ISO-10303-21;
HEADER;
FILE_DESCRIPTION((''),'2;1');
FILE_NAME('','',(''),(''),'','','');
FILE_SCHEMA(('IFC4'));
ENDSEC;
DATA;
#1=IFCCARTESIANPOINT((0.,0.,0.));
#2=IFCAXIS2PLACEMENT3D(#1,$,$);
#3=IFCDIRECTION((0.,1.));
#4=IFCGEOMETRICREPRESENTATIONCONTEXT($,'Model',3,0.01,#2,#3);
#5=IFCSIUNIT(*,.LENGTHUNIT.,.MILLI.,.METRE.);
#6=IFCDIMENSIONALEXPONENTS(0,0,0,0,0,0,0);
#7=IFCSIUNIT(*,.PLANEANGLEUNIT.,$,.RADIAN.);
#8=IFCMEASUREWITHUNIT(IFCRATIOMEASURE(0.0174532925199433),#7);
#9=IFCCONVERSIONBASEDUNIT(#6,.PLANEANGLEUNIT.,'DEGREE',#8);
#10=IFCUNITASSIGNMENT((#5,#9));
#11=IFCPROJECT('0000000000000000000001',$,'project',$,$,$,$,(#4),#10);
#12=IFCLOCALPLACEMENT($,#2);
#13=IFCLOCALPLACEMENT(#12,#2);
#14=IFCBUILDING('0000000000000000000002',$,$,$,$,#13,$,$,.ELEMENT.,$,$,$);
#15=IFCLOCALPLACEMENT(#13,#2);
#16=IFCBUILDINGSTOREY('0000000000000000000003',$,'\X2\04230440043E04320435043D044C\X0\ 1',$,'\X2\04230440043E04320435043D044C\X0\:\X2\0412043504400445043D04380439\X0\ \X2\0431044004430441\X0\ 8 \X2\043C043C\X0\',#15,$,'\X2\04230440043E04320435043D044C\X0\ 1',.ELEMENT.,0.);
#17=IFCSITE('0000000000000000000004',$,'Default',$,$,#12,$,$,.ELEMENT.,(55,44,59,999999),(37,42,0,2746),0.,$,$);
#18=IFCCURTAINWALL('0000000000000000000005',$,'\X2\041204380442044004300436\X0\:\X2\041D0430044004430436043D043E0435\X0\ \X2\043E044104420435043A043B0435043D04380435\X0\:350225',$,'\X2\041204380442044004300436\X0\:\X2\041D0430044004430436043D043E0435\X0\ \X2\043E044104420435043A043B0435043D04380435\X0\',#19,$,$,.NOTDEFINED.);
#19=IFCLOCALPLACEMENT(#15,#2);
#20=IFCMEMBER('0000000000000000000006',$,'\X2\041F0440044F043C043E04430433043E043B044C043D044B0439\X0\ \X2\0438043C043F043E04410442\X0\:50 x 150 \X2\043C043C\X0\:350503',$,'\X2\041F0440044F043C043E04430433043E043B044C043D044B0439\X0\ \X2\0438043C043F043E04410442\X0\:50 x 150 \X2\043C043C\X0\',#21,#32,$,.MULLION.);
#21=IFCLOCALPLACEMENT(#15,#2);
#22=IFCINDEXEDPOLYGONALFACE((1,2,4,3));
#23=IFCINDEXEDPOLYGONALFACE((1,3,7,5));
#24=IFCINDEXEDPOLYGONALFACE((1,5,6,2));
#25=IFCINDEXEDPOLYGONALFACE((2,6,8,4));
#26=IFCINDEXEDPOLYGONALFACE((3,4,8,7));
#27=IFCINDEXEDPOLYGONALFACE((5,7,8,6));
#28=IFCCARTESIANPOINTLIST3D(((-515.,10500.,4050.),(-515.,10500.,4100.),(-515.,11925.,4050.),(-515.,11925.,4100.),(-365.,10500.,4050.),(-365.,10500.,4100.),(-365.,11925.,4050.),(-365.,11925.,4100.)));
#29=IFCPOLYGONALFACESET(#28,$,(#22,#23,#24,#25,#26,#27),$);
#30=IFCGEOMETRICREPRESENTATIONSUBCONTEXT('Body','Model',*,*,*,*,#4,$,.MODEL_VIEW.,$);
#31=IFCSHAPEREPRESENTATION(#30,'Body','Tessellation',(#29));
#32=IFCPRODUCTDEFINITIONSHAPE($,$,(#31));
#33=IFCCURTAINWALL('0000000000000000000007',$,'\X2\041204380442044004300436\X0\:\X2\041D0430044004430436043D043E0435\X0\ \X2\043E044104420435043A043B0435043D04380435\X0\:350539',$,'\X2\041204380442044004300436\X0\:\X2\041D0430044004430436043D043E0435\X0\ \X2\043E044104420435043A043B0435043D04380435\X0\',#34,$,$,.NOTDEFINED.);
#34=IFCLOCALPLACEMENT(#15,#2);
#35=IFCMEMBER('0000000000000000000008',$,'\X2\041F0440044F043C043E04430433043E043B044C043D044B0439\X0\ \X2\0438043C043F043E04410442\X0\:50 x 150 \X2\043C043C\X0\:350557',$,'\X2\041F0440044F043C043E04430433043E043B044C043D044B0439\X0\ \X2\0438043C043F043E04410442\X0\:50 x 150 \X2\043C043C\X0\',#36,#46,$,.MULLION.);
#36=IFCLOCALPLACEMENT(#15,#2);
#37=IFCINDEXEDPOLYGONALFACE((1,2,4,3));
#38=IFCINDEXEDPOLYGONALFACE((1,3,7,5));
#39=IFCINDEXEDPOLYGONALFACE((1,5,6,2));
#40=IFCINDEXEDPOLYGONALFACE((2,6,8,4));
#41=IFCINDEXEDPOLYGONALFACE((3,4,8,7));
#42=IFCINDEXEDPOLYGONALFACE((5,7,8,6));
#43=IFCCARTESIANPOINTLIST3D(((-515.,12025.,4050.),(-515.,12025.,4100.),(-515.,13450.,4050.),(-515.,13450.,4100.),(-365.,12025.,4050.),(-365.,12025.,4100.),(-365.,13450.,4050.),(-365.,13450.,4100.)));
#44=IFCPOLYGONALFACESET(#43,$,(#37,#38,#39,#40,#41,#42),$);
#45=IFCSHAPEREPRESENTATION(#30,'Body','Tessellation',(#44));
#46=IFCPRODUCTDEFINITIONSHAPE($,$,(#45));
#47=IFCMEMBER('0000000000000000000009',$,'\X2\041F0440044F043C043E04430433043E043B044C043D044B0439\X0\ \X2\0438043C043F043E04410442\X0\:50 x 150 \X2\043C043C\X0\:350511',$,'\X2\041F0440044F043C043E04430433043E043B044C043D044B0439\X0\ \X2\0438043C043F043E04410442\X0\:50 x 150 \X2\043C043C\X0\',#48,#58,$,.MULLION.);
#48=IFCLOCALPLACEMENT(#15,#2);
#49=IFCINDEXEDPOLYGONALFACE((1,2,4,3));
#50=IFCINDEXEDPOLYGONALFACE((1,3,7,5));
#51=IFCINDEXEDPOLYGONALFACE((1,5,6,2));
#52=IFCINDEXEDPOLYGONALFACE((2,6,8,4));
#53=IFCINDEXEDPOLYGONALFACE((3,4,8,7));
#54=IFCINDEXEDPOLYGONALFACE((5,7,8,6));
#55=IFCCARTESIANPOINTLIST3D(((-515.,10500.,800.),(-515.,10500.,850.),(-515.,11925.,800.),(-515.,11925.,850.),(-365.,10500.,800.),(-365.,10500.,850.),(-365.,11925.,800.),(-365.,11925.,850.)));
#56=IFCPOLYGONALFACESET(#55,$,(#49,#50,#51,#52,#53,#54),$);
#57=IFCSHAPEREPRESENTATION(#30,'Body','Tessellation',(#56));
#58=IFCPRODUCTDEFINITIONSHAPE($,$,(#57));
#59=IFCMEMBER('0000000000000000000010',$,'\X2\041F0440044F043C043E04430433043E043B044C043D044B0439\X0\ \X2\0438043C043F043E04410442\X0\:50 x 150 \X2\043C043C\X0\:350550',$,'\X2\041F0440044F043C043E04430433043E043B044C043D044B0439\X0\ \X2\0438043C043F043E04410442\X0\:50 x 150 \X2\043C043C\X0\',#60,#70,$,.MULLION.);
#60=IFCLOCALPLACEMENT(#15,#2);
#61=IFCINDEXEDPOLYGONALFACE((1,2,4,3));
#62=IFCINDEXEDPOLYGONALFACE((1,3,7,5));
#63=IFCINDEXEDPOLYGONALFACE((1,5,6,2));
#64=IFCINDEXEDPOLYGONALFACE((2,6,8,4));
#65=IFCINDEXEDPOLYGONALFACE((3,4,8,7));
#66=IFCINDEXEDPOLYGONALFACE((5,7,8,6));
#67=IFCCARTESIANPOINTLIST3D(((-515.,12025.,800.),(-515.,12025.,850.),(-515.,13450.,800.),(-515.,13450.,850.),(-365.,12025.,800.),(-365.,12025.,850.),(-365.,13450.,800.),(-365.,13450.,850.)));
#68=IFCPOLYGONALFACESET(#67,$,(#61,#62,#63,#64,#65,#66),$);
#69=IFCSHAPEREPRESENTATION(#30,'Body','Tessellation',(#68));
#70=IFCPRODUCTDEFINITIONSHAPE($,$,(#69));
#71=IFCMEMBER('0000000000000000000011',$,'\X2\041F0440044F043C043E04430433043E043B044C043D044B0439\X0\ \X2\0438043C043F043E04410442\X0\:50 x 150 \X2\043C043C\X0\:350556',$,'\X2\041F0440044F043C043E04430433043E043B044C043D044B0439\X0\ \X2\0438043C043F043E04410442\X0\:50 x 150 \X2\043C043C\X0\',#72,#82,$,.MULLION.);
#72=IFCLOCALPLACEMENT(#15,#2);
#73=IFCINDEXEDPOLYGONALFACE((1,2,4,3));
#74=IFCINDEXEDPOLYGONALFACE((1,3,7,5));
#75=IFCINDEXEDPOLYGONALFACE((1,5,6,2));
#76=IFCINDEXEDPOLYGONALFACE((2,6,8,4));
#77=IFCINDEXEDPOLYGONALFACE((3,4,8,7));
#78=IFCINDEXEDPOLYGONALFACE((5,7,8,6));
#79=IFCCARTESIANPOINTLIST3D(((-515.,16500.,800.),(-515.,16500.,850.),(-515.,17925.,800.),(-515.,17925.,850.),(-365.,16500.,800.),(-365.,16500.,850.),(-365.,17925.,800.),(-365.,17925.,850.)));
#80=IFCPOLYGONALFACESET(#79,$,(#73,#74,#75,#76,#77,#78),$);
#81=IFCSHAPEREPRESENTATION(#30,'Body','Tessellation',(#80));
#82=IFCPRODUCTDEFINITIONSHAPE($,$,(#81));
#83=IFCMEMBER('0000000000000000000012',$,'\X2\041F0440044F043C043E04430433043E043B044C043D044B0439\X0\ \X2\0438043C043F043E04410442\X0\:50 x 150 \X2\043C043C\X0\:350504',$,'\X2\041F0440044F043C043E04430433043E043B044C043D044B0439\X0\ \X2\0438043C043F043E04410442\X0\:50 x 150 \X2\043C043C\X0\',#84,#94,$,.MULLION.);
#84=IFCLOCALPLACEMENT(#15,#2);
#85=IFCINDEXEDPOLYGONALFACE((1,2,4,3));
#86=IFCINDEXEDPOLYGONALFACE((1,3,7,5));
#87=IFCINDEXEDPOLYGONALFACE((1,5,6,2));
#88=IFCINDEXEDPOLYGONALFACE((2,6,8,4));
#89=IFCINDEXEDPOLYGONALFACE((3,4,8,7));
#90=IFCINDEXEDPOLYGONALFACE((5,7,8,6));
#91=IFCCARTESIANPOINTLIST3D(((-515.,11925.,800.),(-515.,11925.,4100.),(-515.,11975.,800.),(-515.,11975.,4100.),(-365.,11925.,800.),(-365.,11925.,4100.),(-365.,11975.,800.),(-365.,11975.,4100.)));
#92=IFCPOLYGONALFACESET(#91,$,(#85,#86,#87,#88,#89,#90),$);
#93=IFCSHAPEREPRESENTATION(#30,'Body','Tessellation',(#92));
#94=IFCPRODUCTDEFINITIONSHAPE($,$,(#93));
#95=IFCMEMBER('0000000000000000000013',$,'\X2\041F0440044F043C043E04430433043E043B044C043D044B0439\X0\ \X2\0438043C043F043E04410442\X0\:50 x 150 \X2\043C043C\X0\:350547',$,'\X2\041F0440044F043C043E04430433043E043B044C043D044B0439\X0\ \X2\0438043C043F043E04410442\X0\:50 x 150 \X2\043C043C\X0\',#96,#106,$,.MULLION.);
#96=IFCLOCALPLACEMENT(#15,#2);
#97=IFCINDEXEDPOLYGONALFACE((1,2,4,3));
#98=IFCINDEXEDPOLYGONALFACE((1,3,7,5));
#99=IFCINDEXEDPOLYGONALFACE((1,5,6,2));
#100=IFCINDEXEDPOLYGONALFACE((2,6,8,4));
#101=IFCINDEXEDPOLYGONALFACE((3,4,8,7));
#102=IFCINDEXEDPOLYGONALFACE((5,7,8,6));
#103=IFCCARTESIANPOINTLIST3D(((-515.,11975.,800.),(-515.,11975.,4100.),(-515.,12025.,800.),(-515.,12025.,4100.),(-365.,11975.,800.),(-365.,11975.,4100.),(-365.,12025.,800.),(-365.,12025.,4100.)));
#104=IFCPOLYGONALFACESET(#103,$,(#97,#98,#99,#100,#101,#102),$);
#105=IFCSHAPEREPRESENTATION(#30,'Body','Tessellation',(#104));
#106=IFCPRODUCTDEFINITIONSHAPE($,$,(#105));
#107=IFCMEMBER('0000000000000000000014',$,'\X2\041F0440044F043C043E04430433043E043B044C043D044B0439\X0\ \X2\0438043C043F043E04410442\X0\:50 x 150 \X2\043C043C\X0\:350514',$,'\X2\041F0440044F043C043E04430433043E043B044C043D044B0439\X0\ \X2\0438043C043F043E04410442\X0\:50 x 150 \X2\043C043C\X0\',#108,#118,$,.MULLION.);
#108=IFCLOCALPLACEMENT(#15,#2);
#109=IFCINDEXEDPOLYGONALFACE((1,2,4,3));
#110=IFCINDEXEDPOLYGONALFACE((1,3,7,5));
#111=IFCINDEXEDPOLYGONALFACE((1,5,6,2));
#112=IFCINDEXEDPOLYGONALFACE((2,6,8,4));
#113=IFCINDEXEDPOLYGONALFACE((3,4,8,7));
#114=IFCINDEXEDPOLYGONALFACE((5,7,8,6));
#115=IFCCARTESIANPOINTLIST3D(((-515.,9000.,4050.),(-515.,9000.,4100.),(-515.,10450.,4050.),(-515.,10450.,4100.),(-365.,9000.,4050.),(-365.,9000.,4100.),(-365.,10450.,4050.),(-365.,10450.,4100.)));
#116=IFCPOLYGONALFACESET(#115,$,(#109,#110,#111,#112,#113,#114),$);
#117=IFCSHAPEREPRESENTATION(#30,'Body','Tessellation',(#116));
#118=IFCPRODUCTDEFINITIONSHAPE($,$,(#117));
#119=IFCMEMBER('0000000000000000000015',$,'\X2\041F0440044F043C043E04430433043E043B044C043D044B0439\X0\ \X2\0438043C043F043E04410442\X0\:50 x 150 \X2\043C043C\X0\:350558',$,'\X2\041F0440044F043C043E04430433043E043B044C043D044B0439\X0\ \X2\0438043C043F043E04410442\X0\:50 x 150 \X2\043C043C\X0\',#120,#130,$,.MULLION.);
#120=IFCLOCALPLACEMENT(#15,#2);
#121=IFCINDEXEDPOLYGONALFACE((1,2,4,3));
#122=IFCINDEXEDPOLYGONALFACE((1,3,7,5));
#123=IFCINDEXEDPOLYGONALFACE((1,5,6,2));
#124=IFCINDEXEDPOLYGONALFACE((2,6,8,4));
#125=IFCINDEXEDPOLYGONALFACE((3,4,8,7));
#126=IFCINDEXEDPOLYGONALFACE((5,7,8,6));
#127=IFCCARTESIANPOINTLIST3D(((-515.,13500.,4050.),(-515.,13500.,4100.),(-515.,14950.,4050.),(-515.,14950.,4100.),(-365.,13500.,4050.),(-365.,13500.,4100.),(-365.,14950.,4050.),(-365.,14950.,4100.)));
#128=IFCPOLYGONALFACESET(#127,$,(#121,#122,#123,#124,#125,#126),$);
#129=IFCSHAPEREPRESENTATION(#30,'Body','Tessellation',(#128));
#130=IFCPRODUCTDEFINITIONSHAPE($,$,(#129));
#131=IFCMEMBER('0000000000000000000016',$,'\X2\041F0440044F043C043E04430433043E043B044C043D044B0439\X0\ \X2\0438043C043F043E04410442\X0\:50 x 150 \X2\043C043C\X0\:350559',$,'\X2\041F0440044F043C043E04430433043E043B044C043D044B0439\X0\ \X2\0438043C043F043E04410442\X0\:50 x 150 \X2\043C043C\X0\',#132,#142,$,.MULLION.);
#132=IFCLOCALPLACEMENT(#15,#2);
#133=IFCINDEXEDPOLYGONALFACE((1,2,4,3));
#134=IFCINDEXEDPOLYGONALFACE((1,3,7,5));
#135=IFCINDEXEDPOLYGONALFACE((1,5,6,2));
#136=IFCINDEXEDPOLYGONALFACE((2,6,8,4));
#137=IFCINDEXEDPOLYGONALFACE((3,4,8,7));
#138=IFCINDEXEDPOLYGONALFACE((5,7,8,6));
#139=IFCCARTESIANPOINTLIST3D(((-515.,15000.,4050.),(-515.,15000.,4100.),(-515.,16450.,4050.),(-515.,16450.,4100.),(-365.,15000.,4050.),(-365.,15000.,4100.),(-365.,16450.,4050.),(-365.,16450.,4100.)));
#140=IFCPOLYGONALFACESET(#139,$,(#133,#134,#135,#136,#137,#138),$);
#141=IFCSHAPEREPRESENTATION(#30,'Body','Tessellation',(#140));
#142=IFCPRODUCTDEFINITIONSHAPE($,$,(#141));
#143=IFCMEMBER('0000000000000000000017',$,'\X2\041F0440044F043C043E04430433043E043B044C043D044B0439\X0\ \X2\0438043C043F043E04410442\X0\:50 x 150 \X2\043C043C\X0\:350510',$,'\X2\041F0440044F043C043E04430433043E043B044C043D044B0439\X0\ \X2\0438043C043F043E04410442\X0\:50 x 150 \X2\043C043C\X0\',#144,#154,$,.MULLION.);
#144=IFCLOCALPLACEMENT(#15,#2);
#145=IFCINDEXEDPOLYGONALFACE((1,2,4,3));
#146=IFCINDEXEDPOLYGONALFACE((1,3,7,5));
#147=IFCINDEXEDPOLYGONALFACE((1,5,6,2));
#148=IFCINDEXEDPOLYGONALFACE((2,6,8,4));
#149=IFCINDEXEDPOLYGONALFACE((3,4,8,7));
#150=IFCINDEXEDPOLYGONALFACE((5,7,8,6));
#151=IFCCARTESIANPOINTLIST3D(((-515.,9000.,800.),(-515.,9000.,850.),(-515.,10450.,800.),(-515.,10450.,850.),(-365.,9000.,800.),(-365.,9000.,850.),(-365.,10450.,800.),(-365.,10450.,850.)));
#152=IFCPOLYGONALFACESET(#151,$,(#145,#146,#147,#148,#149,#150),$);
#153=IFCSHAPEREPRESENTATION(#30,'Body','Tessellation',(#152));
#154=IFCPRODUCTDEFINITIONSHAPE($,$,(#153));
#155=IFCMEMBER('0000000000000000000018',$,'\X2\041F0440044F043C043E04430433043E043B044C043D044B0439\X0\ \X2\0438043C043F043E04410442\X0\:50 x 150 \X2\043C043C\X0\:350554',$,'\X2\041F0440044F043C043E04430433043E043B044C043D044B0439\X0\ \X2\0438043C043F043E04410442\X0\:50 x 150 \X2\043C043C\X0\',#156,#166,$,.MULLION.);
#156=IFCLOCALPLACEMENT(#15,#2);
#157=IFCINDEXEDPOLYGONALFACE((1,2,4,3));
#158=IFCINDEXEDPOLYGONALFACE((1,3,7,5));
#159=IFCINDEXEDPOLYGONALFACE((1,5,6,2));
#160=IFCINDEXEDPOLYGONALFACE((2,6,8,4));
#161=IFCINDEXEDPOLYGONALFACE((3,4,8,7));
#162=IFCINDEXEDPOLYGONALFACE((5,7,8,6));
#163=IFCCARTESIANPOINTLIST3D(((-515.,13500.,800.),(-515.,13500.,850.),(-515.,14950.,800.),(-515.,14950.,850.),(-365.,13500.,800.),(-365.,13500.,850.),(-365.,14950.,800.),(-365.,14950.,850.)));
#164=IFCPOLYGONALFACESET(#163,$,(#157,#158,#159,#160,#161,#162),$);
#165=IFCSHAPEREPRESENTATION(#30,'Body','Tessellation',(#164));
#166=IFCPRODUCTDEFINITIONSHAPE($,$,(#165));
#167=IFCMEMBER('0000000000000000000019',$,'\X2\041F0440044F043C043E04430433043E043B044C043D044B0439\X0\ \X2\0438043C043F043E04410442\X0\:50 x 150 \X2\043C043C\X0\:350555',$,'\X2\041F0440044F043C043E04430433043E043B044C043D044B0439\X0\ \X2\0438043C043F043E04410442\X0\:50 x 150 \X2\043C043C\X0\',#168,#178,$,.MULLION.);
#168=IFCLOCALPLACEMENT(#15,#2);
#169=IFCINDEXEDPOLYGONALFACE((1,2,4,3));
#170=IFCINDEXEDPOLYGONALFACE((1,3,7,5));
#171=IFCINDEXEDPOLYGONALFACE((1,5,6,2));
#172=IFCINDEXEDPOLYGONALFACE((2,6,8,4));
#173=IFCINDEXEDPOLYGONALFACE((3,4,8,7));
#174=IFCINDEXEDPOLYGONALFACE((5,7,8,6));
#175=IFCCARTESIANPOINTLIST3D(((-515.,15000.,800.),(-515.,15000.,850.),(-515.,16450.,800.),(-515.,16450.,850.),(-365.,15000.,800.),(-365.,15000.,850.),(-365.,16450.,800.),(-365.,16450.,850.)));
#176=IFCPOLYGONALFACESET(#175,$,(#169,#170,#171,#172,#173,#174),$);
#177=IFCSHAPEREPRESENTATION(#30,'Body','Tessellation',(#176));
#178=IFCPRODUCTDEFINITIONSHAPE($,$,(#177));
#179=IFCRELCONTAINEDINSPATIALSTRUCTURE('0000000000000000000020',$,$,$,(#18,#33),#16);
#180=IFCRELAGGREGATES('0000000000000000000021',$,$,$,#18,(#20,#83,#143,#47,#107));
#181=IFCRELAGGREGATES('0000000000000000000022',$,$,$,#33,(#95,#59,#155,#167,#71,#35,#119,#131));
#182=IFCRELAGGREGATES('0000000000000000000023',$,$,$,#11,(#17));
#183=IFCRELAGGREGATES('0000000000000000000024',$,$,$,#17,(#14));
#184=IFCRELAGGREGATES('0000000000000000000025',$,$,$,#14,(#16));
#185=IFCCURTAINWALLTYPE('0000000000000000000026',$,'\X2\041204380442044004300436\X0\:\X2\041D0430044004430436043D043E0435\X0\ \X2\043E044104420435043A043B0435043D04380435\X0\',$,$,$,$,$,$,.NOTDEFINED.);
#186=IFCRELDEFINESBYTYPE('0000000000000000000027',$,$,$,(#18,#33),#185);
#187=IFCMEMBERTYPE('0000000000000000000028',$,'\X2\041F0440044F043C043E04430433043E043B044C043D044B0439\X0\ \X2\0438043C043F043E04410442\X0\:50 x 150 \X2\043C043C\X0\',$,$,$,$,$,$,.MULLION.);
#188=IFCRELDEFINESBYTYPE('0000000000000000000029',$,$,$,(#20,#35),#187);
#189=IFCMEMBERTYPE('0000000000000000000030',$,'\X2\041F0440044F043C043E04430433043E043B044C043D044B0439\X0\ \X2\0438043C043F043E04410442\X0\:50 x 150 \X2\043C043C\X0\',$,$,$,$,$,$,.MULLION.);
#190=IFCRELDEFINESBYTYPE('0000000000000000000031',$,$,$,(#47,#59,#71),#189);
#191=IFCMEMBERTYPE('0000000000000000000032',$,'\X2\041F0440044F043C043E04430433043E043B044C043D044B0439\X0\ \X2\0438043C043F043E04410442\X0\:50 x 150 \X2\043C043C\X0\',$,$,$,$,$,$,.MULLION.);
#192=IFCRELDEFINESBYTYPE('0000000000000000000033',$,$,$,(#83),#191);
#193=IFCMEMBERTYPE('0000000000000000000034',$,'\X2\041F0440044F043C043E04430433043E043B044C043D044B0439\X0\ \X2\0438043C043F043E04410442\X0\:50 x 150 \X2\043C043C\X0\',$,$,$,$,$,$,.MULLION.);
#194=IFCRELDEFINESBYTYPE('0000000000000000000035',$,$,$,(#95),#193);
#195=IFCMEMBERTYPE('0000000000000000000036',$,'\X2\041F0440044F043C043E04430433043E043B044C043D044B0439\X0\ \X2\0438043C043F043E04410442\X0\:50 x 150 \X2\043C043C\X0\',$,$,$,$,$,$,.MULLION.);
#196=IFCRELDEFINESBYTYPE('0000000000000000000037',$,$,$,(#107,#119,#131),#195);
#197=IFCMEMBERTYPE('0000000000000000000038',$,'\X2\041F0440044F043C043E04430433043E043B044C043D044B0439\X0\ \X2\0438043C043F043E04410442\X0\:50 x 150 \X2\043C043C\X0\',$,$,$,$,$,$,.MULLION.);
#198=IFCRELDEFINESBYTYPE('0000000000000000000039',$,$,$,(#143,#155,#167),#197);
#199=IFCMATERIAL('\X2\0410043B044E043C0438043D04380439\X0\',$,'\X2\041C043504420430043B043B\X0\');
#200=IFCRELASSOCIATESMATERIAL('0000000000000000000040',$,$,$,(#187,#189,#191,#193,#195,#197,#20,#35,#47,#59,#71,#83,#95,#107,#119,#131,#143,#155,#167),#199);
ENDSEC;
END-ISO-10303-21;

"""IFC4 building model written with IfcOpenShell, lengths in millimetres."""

from ifc_helpers import new_model, entity, si_unit, converted_unit, direction, frame, origin, origin_2d_with_axis, place, context, subcontext, project, spatial, rectangle, extrude, source, transform, mapped, material, material_profile, profile_set, profile_usage, type_object, type_shapes, element, aggregate, save


model = new_model("IFC4")

# Units and contexts
model_context = context("Model", 3, precision=0.01, world=origin(), true_north=direction((0.0, 1.0)))
body_context = subcontext(model_context, "Body", "Model", "MODEL_VIEW")
ifc_project = project(units=[si_unit("LENGTHUNIT", "METRE", prefix="MILLI"), converted_unit("PLANEANGLEUNIT", "DEGREE", entity("IfcRatioMeasure", 0.0174532925199433), si_unit("PLANEANGLEUNIT", "RADIAN"), dimensions=[0, 0, 0, 0, 0, 0, 0])], contexts=[model_context])

# Site, building, storey
site_placement = place(None, origin())
site = spatial("IfcSite", under=ifc_project, at=site_placement, Name="Default", CompositionType="ELEMENT", RefLatitude=(55, 44, 59, 999999), RefLongitude=(37, 42, 0, 2746), RefElevation=0.0)
building_placement = place(site_placement, origin())
building = spatial("IfcBuilding", under=site, at=building_placement, CompositionType="ELEMENT")
storey_placement = place(building_placement, origin())
storey = spatial("IfcBuildingStorey", under=building, at=storey_placement, Name="Уровень 1", ObjectType="Уровень:Верхний брус 8 мм", LongName="Уровень 1", CompositionType="ELEMENT", Elevation=0.0)

# Curtain walls, members
curtain_wall_type = type_object("IfcCurtainWallType", Name="Витраж:Наружное остекление", PredefinedType="NOTDEFINED")
curtain_wall_1_placement = place(storey_placement, origin())
curtain_wall_1 = element("IfcCurtainWall", 1, at=curtain_wall_1_placement, inside=storey, type_object=curtain_wall_type, Name="Витраж:Наружное остекление:350225", ObjectType="Витраж:Наружное остекление", PredefinedType="NOTDEFINED")
ifc_material_1 = material(Name="Алюминий", Category="Металл")
ifc_material_profile = material_profile(ifc_material_1, rectangle(XDim=150.0, YDim=50.0, at=origin_2d_with_axis()), Name="50 x 150 мм")
ifc_profile_set = profile_set([ifc_material_profile], Name="50 x 150 мм")
ifc_profile_usage_1 = profile_usage(ifc_profile_set)
member_type_1 = type_object("IfcMemberType", Name="Прямоугольный импост:50 x 150 мм", PredefinedType="MULLION", material=ifc_profile_set)
shared_shape_1 = source(origin(), body_context, "Body", "SweptSolid", [
    extrude(rectangle(XDim=150.0, YDim=50.0, at=origin_2d_with_axis()), frame((-25.0, 0.0, -1425.0), z_axis=(0.0, 0.0, 1.0), x_axis=(0.0, -1.0, 0.0)), (0.0, 0.0, 1.0), 1425.0),
])
type_shapes(member_type_1, [shared_shape_1])
member_1_placement = place(storey_placement, frame((-440.0, 11925.0, 4100.0), z_axis=(0.0, 1.0, 0.0), x_axis=(0.0, 0.0, 1.0)))
member_1 = element("IfcMember", 2, at=member_1_placement, type_object=member_type_1, material=ifc_profile_usage_1, Name="Прямоугольный импост:50 x 150 мм:350503", ObjectType="Прямоугольный импост:50 x 150 мм", PredefinedType="MULLION", context=body_context, shape_type="MappedRepresentation", body=[
    mapped(shared_shape_1, transform((0.0, 0.0, 0.0), scale=1.0)),
])
curtain_wall_2_placement = place(storey_placement, origin())
curtain_wall_2 = element("IfcCurtainWall", 3, at=curtain_wall_2_placement, inside=storey, type_object=curtain_wall_type, Name="Витраж:Наружное остекление:350539", ObjectType="Витраж:Наружное остекление", PredefinedType="NOTDEFINED")
ifc_profile_usage_2 = profile_usage(ifc_profile_set)
member_2_placement = place(storey_placement, frame((-440.0, 13450.0, 4100.0), z_axis=(0.0, 1.0, 0.0), x_axis=(0.0, 0.0, 1.0)))
member_2 = element("IfcMember", 4, at=member_2_placement, type_object=member_type_1, material=ifc_profile_usage_2, Name="Прямоугольный импост:50 x 150 мм:350557", ObjectType="Прямоугольный импост:50 x 150 мм", PredefinedType="MULLION", context=body_context, shape_type="MappedRepresentation", body=[
    mapped(shared_shape_1, transform((0.0, 0.0, 0.0), scale=1.0)),
])

# Members
ifc_profile_usage_3 = profile_usage(ifc_profile_set)
member_type_2 = type_object("IfcMemberType", Name="Прямоугольный импост:50 x 150 мм", PredefinedType="MULLION", material=ifc_profile_set)
shared_shape_2 = source(origin(), body_context, "Body", "SweptSolid", [
    extrude(rectangle(XDim=150.0, YDim=50.0, at=origin_2d_with_axis()), frame((-25.0, 0.0, -1425.0), z_axis=(0.0, 0.0, 1.0), x_axis=(0.0, -1.0, 0.0)), (0.0, 0.0, 1.0), 1425.0),
])
type_shapes(member_type_2, [shared_shape_2])
member_3_placement = place(storey_placement, frame((-440.0, 10500.0, 800.0), z_axis=(0.0, -1.0, 0.0), x_axis=(0.0, 0.0, -1.0)))
member_3 = element("IfcMember", 5, at=member_3_placement, type_object=member_type_2, material=ifc_profile_usage_3, Name="Прямоугольный импост:50 x 150 мм:350511", ObjectType="Прямоугольный импост:50 x 150 мм", PredefinedType="MULLION", context=body_context, shape_type="MappedRepresentation", body=[
    mapped(shared_shape_2, transform((0.0, 0.0, 0.0), scale=1.0)),
])
ifc_profile_usage_4 = profile_usage(ifc_profile_set)
member_4_placement = place(storey_placement, frame((-440.0, 12025.0, 800.0), z_axis=(0.0, -1.0, 0.0), x_axis=(0.0, 0.0, -1.0)))
member_4 = element("IfcMember", 6, at=member_4_placement, type_object=member_type_2, material=ifc_profile_usage_4, Name="Прямоугольный импост:50 x 150 мм:350550", ObjectType="Прямоугольный импост:50 x 150 мм", PredefinedType="MULLION", context=body_context, shape_type="MappedRepresentation", body=[
    mapped(shared_shape_2, transform((0.0, 0.0, 0.0), scale=1.0)),
])
ifc_profile_usage_5 = profile_usage(ifc_profile_set)
member_5_placement = place(storey_placement, frame((-440.0, 16500.0, 800.0), z_axis=(0.0, -1.0, 0.0), x_axis=(0.0, 0.0, -1.0)))
member_5 = element("IfcMember", 7, at=member_5_placement, type_object=member_type_2, material=ifc_profile_usage_5, Name="Прямоугольный импост:50 x 150 мм:350556", ObjectType="Прямоугольный импост:50 x 150 мм", PredefinedType="MULLION", context=body_context, shape_type="MappedRepresentation", body=[
    mapped(shared_shape_2, transform((0.0, 0.0, 0.0), scale=1.0)),
])
ifc_profile_usage_6 = profile_usage(ifc_profile_set)
member_type_3 = type_object("IfcMemberType", Name="Прямоугольный импост:50 x 150 мм", PredefinedType="MULLION", material=ifc_profile_set)
shared_shape_3 = source(origin(), body_context, "Body", "SweptSolid", [
    extrude(rectangle(XDim=150.0, YDim=50.0, at=origin_2d_with_axis()), frame((-25.0, 0.0, -3300.0), z_axis=(0.0, 0.0, 1.0), x_axis=(0.0, -1.0, 0.0)), (0.0, 0.0, 1.0), 3300.0),
])
type_shapes(member_type_3, [shared_shape_3])
member_6_placement = place(storey_placement, frame((-440.0, 11975.0, 800.0), z_axis=(0.0, 0.0, -1.0), x_axis=(0.0, 1.0, 0.0)))
member_6 = element("IfcMember", 8, at=member_6_placement, type_object=member_type_3, material=ifc_profile_usage_6, Name="Прямоугольный импост:50 x 150 мм:350504", ObjectType="Прямоугольный импост:50 x 150 мм", PredefinedType="MULLION", context=body_context, shape_type="MappedRepresentation", body=[
    mapped(shared_shape_3, transform((0.0, 0.0, 0.0), scale=1.0)),
])
ifc_profile_usage_7 = profile_usage(ifc_profile_set)
member_type_4 = type_object("IfcMemberType", Name="Прямоугольный импост:50 x 150 мм", PredefinedType="MULLION", material=ifc_profile_set)
shared_shape_4 = source(origin(), body_context, "Body", "SweptSolid", [
    extrude(rectangle(XDim=150.0, YDim=50.0, at=origin_2d_with_axis()), frame((-25.0, 0.0, -3300.0), z_axis=(0.0, 0.0, 1.0), x_axis=(0.0, -1.0, 0.0)), (0.0, 0.0, 1.0), 3300.0),
])
type_shapes(member_type_4, [shared_shape_4])
member_7_placement = place(storey_placement, frame((-440.0, 11975.0, 4100.0), z_axis=(0.0, 0.0, 1.0), x_axis=(0.0, -1.0, 0.0)))
member_7 = element("IfcMember", 9, at=member_7_placement, type_object=member_type_4, material=ifc_profile_usage_7, Name="Прямоугольный импост:50 x 150 мм:350547", ObjectType="Прямоугольный импост:50 x 150 мм", PredefinedType="MULLION", context=body_context, shape_type="MappedRepresentation", body=[
    mapped(shared_shape_4, transform((0.0, 0.0, 0.0), scale=1.0)),
])
ifc_profile_usage_8 = profile_usage(ifc_profile_set)
member_type_5 = type_object("IfcMemberType", Name="Прямоугольный импост:50 x 150 мм", PredefinedType="MULLION", material=ifc_profile_set)
shared_shape_5 = source(origin(), body_context, "Body", "SweptSolid", [
    extrude(rectangle(XDim=150.0, YDim=50.0, at=origin_2d_with_axis()), frame((-25.0, 0.0, -1450.0), z_axis=(0.0, 0.0, 1.0), x_axis=(0.0, -1.0, 0.0)), (0.0, 0.0, 1.0), 1450.0),
])
type_shapes(member_type_5, [shared_shape_5])
member_8_placement = place(storey_placement, frame((-440.0, 10450.0, 4100.0), z_axis=(0.0, 1.0, 0.0), x_axis=(0.0, 0.0, 1.0)))
member_8 = element("IfcMember", 10, at=member_8_placement, type_object=member_type_5, material=ifc_profile_usage_8, Name="Прямоугольный импост:50 x 150 мм:350514", ObjectType="Прямоугольный импост:50 x 150 мм", PredefinedType="MULLION", context=body_context, shape_type="MappedRepresentation", body=[
    mapped(shared_shape_5, transform((0.0, 0.0, 0.0), scale=1.0)),
])
ifc_profile_usage_9 = profile_usage(ifc_profile_set)
member_9_placement = place(storey_placement, frame((-440.0, 14950.0, 4100.0), z_axis=(0.0, 1.0, 0.0), x_axis=(0.0, 0.0, 1.0)))
member_9 = element("IfcMember", 11, at=member_9_placement, type_object=member_type_5, material=ifc_profile_usage_9, Name="Прямоугольный импост:50 x 150 мм:350558", ObjectType="Прямоугольный импост:50 x 150 мм", PredefinedType="MULLION", context=body_context, shape_type="MappedRepresentation", body=[
    mapped(shared_shape_5, transform((0.0, 0.0, 0.0), scale=1.0)),
])
ifc_profile_usage_10 = profile_usage(ifc_profile_set)
member_10_placement = place(storey_placement, frame((-440.0, 16450.0, 4100.0), z_axis=(0.0, 1.0, 0.0), x_axis=(0.0, 0.0, 1.0)))
member_10 = element("IfcMember", 12, at=member_10_placement, type_object=member_type_5, material=ifc_profile_usage_10, Name="Прямоугольный импост:50 x 150 мм:350559", ObjectType="Прямоугольный импост:50 x 150 мм", PredefinedType="MULLION", context=body_context, shape_type="MappedRepresentation", body=[
    mapped(shared_shape_5, transform((0.0, 0.0, 0.0), scale=1.0)),
])
ifc_profile_usage_11 = profile_usage(ifc_profile_set)
member_type_6 = type_object("IfcMemberType", Name="Прямоугольный импост:50 x 150 мм", PredefinedType="MULLION", material=ifc_profile_set)
shared_shape_6 = source(origin(), body_context, "Body", "SweptSolid", [
    extrude(rectangle(XDim=150.0, YDim=50.0, at=origin_2d_with_axis()), frame((-25.0, 0.0, -1450.0), z_axis=(0.0, 0.0, 1.0), x_axis=(0.0, -1.0, 0.0)), (0.0, 0.0, 1.0), 1450.0),
])
type_shapes(member_type_6, [shared_shape_6])
member_11_placement = place(storey_placement, frame((-440.0, 9000.0, 800.0), z_axis=(0.0, -1.0, 0.0), x_axis=(0.0, 0.0, -1.0)))
member_11 = element("IfcMember", 13, at=member_11_placement, type_object=member_type_6, material=ifc_profile_usage_11, Name="Прямоугольный импост:50 x 150 мм:350510", ObjectType="Прямоугольный импост:50 x 150 мм", PredefinedType="MULLION", context=body_context, shape_type="MappedRepresentation", body=[
    mapped(shared_shape_6, transform((0.0, 0.0, 0.0), scale=1.0)),
])
ifc_profile_usage_12 = profile_usage(ifc_profile_set)
member_12_placement = place(storey_placement, frame((-440.0, 13500.0, 800.0), z_axis=(0.0, -1.0, 0.0), x_axis=(0.0, 0.0, -1.0)))
member_12 = element("IfcMember", 14, at=member_12_placement, type_object=member_type_6, material=ifc_profile_usage_12, Name="Прямоугольный импост:50 x 150 мм:350554", ObjectType="Прямоугольный импост:50 x 150 мм", PredefinedType="MULLION", context=body_context, shape_type="MappedRepresentation", body=[
    mapped(shared_shape_6, transform((0.0, 0.0, 0.0), scale=1.0)),
])
ifc_profile_usage_13 = profile_usage(ifc_profile_set)
member_13_placement = place(storey_placement, frame((-440.0, 15000.0, 800.0), z_axis=(0.0, -1.0, 0.0), x_axis=(0.0, 0.0, -1.0)))
member_13 = element("IfcMember", 15, at=member_13_placement, type_object=member_type_6, material=ifc_profile_usage_13, Name="Прямоугольный импост:50 x 150 мм:350555", ObjectType="Прямоугольный импост:50 x 150 мм", PredefinedType="MULLION", context=body_context, shape_type="MappedRepresentation", body=[
    mapped(shared_shape_6, transform((0.0, 0.0, 0.0), scale=1.0)),
])

aggregate(curtain_wall_1, [member_1, member_6, member_11, member_3, member_8])
aggregate(curtain_wall_2, [member_7, member_4, member_12, member_13, member_5, member_2, member_9, member_10])

save(model, "model.ifc")
